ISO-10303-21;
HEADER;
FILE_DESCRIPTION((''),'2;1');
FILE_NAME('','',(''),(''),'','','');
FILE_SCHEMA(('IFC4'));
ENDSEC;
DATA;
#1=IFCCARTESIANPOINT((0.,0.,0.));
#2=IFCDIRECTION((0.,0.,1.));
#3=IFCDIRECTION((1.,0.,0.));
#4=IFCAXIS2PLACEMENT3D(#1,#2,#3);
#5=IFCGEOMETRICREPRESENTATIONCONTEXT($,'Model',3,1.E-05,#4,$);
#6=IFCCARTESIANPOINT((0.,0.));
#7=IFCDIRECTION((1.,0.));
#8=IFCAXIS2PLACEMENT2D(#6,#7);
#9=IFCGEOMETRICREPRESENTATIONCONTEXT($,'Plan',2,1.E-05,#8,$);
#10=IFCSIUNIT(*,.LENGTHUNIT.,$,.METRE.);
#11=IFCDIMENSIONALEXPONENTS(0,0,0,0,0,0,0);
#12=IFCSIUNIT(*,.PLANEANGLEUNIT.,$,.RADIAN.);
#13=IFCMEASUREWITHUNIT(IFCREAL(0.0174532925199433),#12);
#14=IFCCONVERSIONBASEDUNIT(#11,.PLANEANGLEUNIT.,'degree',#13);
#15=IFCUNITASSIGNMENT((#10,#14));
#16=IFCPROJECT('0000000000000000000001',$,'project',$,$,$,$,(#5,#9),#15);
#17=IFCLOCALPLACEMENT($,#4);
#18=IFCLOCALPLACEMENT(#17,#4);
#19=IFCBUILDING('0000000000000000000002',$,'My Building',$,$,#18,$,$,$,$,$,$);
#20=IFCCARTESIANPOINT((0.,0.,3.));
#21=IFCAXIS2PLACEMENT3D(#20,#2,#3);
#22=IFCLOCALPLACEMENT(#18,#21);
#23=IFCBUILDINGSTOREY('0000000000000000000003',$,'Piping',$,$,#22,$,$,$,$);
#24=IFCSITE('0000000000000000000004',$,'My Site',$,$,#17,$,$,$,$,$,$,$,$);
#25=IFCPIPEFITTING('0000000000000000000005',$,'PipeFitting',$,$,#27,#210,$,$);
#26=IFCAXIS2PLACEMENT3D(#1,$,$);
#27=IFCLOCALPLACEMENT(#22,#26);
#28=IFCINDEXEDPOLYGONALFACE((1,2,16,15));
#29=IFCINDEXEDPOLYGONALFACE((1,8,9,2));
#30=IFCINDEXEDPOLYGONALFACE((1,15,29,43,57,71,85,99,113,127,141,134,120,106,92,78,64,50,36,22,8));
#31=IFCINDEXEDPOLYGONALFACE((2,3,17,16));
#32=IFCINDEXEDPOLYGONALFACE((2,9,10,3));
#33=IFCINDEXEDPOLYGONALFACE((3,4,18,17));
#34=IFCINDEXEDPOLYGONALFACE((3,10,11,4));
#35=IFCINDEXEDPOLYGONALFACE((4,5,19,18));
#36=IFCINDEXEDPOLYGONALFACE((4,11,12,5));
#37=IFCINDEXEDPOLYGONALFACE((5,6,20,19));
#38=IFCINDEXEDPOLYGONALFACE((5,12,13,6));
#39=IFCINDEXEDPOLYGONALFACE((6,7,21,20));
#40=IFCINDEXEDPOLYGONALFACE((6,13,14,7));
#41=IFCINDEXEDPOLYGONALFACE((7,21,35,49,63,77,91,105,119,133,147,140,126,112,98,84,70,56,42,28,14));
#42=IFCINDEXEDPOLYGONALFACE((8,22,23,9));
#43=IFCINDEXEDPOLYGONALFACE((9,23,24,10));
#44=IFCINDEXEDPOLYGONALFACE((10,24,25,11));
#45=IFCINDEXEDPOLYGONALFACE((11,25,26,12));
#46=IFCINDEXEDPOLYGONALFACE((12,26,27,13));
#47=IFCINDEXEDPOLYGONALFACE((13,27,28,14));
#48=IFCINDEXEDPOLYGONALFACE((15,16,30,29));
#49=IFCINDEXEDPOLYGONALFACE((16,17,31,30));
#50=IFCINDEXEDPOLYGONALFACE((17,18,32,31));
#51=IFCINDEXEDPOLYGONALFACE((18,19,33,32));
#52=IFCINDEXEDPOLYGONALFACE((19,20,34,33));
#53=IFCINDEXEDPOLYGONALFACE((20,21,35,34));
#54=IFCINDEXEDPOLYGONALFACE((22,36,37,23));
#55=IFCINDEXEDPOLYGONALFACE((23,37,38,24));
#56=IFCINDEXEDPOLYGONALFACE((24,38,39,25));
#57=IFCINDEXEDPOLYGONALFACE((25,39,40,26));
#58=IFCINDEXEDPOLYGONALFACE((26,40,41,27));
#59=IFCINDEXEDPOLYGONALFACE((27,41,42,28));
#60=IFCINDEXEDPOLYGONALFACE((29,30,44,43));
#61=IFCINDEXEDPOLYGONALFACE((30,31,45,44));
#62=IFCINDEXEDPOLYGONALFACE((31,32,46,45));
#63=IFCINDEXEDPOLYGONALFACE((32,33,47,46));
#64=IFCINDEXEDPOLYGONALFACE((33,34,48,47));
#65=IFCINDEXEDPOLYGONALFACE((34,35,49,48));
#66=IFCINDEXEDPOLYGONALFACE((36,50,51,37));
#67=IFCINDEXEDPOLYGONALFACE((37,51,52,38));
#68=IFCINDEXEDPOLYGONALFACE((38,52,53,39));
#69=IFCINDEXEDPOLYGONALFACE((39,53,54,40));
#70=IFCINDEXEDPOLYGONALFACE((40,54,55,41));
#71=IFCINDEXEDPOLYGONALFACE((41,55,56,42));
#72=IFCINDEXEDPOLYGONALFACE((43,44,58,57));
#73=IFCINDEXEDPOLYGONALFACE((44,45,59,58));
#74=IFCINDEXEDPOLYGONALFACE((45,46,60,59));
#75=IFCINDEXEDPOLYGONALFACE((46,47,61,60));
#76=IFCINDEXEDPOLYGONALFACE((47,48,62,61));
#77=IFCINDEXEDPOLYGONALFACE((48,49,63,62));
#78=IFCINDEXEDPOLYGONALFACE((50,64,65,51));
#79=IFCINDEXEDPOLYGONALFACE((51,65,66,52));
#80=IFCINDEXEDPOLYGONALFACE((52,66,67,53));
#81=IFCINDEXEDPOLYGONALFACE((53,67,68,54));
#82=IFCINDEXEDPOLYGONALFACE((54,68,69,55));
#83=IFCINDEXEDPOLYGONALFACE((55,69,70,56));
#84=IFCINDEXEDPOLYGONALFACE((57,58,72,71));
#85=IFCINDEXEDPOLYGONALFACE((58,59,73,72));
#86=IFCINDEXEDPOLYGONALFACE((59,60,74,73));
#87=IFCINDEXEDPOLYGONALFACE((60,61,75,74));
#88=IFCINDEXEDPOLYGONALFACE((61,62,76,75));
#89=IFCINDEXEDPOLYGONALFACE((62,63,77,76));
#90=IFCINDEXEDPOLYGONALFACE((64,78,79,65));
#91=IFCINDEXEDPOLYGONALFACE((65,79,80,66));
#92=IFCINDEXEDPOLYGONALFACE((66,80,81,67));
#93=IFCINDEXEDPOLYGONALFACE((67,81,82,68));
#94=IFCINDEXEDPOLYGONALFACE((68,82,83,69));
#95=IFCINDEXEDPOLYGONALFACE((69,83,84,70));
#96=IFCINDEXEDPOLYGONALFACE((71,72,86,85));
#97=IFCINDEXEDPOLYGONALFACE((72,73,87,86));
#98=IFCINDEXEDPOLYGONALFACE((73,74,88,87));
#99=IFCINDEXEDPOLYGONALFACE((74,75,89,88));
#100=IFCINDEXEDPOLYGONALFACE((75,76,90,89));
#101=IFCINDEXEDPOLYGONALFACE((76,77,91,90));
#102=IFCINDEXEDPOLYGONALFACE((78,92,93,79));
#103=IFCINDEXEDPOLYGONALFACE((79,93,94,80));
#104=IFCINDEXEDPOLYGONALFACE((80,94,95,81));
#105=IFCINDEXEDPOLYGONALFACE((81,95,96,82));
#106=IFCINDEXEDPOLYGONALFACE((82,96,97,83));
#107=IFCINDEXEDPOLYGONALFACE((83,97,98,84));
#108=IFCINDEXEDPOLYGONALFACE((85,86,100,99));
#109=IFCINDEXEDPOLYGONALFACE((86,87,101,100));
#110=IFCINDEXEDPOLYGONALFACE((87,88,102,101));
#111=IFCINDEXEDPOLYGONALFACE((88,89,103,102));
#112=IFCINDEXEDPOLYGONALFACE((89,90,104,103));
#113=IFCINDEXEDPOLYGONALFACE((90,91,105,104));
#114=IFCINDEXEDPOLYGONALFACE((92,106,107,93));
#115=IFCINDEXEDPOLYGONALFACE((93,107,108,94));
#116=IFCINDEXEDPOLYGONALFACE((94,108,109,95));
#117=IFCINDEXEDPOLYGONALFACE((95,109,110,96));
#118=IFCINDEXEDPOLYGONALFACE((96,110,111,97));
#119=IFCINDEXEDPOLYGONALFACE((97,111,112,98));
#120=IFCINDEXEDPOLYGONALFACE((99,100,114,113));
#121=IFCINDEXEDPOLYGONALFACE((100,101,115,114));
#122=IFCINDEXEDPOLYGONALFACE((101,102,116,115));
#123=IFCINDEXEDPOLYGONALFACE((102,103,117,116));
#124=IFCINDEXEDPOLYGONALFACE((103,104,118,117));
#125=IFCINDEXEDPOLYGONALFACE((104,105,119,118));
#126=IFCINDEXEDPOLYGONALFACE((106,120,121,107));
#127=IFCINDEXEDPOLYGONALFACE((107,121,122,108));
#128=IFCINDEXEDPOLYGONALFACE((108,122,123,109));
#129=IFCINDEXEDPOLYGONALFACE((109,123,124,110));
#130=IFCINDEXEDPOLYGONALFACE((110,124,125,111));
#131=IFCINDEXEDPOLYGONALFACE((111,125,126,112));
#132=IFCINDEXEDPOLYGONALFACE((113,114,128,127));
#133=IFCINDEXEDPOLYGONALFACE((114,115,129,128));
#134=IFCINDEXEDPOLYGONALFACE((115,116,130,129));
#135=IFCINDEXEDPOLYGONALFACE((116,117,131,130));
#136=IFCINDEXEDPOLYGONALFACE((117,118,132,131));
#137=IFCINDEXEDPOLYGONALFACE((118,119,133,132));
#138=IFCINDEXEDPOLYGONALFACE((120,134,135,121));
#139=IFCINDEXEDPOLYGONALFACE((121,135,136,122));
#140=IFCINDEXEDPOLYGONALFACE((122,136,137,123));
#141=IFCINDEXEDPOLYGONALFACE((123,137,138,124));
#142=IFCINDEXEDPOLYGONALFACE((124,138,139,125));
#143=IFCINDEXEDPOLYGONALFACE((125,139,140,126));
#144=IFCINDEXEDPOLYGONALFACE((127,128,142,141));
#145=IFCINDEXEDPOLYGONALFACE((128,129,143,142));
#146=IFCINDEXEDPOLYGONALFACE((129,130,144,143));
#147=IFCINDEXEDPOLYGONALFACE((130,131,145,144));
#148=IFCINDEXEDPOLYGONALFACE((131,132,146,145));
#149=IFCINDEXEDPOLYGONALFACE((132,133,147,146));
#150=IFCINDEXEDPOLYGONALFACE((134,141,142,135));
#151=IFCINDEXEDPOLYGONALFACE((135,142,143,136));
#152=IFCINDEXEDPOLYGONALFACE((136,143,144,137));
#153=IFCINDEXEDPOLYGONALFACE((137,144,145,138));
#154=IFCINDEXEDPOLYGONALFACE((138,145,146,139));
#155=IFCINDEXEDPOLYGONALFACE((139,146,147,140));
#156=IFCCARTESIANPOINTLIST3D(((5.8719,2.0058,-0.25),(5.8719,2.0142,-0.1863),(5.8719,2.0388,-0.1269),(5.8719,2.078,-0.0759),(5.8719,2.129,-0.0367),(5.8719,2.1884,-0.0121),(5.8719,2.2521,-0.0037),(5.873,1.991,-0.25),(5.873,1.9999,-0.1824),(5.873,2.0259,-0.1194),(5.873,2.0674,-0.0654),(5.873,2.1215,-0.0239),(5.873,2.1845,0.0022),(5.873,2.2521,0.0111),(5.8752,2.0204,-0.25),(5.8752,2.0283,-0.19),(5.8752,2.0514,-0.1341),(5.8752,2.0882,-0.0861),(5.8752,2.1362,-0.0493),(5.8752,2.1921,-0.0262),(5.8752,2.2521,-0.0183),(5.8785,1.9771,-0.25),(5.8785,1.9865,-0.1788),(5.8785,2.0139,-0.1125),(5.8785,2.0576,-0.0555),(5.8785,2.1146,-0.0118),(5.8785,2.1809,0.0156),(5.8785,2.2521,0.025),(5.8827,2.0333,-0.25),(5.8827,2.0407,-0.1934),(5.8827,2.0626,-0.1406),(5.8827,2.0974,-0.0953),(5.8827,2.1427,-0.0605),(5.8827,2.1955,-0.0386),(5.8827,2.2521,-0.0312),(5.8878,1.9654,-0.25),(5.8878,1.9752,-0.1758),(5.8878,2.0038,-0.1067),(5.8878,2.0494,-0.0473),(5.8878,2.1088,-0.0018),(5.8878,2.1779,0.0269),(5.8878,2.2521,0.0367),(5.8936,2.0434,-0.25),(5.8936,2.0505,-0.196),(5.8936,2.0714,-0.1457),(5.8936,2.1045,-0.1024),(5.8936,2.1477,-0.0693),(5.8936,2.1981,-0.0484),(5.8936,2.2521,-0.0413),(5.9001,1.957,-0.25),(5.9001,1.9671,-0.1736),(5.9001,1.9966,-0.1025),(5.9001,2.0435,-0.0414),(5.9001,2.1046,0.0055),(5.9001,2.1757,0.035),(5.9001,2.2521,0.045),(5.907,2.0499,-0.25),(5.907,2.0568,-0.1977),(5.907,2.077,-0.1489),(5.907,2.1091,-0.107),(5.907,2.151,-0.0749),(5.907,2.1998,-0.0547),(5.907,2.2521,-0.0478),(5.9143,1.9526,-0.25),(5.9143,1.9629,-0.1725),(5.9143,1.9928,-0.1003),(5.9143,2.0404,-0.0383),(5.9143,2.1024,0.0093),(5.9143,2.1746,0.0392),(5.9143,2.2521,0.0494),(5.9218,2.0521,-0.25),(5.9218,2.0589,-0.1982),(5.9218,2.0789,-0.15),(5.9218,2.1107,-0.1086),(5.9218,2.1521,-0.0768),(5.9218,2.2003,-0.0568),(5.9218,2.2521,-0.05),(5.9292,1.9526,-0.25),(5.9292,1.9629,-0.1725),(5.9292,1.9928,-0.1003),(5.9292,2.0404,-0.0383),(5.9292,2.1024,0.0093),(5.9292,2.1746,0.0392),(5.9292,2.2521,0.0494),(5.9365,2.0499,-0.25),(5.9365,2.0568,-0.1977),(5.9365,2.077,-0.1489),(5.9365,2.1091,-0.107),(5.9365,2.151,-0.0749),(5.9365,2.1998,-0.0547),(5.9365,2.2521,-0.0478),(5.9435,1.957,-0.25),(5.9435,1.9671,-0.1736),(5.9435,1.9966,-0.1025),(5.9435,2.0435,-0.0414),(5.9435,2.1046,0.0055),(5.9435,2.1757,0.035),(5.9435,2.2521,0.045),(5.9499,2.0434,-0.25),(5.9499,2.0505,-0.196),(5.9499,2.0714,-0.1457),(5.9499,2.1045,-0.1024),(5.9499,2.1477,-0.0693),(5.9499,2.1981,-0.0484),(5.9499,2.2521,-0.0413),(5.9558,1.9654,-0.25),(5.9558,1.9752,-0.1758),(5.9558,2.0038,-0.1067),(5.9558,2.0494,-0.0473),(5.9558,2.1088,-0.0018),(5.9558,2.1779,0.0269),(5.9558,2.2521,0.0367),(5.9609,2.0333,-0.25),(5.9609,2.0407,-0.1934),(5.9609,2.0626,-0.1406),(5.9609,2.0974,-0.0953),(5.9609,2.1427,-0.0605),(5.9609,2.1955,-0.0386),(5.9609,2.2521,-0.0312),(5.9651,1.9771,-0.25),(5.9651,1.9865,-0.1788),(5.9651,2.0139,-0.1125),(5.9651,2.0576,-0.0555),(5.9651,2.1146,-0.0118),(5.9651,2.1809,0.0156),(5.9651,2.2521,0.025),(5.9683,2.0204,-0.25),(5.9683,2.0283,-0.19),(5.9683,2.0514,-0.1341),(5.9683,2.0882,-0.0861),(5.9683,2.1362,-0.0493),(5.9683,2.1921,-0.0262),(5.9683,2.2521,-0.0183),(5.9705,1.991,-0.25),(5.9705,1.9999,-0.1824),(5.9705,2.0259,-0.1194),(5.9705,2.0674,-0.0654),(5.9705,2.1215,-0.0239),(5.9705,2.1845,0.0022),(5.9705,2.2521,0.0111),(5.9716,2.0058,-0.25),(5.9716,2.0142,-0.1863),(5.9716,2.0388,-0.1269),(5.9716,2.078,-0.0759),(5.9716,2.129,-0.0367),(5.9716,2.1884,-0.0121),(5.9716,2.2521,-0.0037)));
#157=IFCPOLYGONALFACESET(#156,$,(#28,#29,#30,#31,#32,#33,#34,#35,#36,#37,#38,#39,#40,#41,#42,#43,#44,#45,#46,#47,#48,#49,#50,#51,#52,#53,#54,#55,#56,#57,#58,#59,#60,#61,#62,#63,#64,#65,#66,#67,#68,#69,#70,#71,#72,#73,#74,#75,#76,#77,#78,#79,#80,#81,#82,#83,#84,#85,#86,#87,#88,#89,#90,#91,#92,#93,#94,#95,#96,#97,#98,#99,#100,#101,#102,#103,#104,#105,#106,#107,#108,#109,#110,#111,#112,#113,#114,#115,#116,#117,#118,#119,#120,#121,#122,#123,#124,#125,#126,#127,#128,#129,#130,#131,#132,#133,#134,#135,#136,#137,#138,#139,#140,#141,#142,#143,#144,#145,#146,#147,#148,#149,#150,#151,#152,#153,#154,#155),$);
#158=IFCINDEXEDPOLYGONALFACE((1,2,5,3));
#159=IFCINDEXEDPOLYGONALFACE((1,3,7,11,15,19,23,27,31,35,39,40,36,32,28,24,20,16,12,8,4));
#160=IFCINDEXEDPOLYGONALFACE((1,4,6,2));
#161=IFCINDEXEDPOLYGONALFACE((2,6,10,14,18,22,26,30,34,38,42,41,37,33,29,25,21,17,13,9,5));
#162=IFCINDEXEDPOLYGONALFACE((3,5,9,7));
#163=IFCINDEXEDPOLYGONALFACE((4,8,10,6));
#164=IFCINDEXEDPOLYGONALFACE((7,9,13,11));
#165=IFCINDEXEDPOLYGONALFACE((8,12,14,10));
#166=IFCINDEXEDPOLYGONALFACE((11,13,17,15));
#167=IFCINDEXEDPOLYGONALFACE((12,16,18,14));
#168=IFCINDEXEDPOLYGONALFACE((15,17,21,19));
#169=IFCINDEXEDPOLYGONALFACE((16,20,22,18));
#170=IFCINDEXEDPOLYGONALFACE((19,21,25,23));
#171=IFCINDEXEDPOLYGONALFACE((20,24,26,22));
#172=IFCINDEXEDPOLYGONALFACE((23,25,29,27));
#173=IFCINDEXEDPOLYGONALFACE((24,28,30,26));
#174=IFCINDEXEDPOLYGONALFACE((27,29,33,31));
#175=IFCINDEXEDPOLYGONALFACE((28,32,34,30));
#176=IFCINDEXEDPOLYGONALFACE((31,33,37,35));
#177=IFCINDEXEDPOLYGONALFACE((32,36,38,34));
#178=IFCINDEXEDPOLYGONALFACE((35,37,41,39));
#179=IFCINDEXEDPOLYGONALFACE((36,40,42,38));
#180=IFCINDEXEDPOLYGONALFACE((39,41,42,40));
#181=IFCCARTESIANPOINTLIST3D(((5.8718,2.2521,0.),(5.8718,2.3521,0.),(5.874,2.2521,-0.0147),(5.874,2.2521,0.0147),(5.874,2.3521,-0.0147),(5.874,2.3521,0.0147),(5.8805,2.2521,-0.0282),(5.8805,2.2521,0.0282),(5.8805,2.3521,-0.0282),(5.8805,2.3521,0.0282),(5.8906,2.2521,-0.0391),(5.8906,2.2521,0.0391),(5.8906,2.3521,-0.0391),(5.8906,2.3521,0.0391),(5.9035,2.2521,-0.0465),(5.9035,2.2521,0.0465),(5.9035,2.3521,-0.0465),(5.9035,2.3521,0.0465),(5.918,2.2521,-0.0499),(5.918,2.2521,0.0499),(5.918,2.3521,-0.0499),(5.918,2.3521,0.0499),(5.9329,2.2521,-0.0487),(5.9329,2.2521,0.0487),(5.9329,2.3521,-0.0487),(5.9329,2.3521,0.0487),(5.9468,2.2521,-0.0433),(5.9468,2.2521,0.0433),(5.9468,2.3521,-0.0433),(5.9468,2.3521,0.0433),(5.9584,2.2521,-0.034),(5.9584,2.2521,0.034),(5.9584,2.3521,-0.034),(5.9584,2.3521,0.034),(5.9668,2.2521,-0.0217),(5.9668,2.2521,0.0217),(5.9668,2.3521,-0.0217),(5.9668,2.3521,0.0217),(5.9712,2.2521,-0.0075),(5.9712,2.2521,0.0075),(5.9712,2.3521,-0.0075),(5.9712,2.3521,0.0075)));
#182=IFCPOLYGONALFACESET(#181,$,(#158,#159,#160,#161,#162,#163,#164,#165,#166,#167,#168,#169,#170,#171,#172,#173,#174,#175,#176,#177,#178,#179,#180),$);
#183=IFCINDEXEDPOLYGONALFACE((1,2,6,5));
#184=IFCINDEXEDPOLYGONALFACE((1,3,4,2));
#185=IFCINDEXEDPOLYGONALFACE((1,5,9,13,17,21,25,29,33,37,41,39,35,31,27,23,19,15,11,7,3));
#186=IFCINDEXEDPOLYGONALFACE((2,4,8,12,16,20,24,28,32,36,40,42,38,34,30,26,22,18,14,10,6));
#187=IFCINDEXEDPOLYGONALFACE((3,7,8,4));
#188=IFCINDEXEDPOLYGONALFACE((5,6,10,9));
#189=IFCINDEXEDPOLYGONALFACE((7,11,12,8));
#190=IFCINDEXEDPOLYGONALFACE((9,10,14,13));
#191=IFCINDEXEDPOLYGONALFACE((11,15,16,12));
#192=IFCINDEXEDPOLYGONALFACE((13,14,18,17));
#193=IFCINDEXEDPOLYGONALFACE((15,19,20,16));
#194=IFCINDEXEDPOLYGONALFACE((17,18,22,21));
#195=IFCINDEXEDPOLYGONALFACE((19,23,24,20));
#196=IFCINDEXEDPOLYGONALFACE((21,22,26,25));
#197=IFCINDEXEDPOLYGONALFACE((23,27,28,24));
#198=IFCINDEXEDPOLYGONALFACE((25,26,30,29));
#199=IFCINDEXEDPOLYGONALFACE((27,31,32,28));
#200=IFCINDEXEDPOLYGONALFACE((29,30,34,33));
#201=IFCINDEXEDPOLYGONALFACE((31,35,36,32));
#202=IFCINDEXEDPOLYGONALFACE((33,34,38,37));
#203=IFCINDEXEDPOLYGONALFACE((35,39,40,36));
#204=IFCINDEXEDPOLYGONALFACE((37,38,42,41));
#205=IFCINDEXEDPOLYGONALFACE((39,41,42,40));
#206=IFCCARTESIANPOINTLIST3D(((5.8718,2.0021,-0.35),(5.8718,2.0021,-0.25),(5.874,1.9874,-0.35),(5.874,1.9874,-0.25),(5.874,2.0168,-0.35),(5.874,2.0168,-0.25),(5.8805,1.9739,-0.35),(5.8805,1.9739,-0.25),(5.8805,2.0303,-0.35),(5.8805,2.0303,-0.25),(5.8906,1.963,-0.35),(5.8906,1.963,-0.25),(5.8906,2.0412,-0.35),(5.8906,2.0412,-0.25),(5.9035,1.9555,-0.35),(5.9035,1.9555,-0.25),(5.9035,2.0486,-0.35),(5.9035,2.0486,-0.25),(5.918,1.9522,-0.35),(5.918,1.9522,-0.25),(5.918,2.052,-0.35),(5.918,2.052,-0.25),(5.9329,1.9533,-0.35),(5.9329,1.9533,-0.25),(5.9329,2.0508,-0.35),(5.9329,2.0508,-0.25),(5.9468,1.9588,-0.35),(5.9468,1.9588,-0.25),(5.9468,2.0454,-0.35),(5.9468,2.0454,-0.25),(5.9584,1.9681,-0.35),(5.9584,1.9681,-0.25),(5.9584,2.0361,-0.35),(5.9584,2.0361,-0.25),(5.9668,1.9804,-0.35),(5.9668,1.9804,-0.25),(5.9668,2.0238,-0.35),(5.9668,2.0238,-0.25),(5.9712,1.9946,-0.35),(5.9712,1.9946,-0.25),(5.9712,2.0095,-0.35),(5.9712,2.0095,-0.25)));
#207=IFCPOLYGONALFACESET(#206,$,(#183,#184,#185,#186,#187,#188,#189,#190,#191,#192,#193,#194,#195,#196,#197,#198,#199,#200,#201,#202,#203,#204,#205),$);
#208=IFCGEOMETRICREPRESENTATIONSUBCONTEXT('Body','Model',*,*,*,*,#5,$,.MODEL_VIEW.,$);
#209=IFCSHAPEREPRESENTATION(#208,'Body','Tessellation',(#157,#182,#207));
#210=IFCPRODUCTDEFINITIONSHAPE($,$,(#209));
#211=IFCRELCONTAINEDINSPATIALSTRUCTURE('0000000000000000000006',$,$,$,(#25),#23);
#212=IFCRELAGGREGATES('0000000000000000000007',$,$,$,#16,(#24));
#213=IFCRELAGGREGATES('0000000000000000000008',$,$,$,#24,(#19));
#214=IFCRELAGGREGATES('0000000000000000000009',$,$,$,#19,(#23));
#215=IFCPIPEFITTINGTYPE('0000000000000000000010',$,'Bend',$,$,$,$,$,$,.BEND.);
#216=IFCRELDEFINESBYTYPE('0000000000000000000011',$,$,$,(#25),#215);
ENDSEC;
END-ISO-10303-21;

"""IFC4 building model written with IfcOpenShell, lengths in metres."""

from ifc_helpers import new_model, entity, si_unit, converted_unit, frame, origin_with_axes, origin_2d_with_axis, place, context, subcontext, project, spatial, circle, extrude, source, transform, mapped, type_object, type_shapes, element, save


model = new_model("IFC4")

# Units and contexts
model_context = context("Model", 3, precision=1e-05, world=origin_with_axes())
plan_context = context("Plan", 2, precision=1e-05, world=origin_2d_with_axis())
body_context = subcontext(model_context, "Body", "Model", "MODEL_VIEW")
ifc_project = project(units=[si_unit("LENGTHUNIT", "METRE"), converted_unit("PLANEANGLEUNIT", "degree", entity("IfcReal", 0.0174532925199433), si_unit("PLANEANGLEUNIT", "RADIAN"), dimensions=[0, 0, 0, 0, 0, 0, 0])], contexts=[model_context, plan_context])

# Site, building, storey
site_placement = place(None, origin_with_axes())
site = spatial("IfcSite", under=ifc_project, at=site_placement, Name="My Site")
building_placement = place(site_placement, origin_with_axes())
building = spatial("IfcBuilding", under=site, at=building_placement, Name="My Building")
storey_placement = place(building_placement, frame((0.0, 0.0, 3.0), z_axis=(0.0, 0.0, 1.0), x_axis=(1.0, 0.0, 0.0)))
storey = spatial("IfcBuildingStorey", under=building, at=storey_placement, Name="Piping")

# Pipe fitting
pipe_fitting_type_1 = type_object("IfcPipeFittingType", Name="Bend", PredefinedType="BEND")
shared_shape = source(origin_with_axes(), body_context, "Body", "SolidModel", [
    entity("IfcSweptDiskSolid", entity("IfcIndexedPolyCurve", entity("IfcCartesianPointList3D", [[0.0, 0.0, -0.1], [0.0, -0.0732, -0.2768], [0.0, -0.25, -0.35]]), [entity("IfcArcIndex", [1, 2, 3])]), 0.05),
    extrude(circle(Radius=0.05), origin_with_axes(), (0.0, 0.0, -1.0), 0.1),
    extrude(circle(Radius=0.05), frame((0.0, -0.25, -0.35), z_axis=(0.0, -1.0, 0.0), x_axis=(1.0, 0.0, 0.0)), (0.0, 0.0, 1.0), 0.1),
])
type_shapes(pipe_fitting_type_1, [shared_shape])
for number, where, z_axis, x_axis, name in (
    (1, (5.9218, 2.3521, 0.0), (0.0, 1.0, 0.0), (-1.0, 0.0, 0.0), "PipeFitting"),
):
    element("IfcPipeFitting", number, at=place(storey_placement, frame(where, z_axis=z_axis, x_axis=x_axis)), inside=storey, type_object=pipe_fitting_type_1, Name=name, context=body_context, shape_type="MappedRepresentation", body=[
        mapped(shared_shape, transform((0.0, 0.0, 0.0), x_axis=(1.0, 0.0, 0.0), y_axis=(0.0, 1.0, 0.0), z_axis=(0.0, 0.0, 1.0), scale=1.0)),
    ])

save(model, "model.ifc")
